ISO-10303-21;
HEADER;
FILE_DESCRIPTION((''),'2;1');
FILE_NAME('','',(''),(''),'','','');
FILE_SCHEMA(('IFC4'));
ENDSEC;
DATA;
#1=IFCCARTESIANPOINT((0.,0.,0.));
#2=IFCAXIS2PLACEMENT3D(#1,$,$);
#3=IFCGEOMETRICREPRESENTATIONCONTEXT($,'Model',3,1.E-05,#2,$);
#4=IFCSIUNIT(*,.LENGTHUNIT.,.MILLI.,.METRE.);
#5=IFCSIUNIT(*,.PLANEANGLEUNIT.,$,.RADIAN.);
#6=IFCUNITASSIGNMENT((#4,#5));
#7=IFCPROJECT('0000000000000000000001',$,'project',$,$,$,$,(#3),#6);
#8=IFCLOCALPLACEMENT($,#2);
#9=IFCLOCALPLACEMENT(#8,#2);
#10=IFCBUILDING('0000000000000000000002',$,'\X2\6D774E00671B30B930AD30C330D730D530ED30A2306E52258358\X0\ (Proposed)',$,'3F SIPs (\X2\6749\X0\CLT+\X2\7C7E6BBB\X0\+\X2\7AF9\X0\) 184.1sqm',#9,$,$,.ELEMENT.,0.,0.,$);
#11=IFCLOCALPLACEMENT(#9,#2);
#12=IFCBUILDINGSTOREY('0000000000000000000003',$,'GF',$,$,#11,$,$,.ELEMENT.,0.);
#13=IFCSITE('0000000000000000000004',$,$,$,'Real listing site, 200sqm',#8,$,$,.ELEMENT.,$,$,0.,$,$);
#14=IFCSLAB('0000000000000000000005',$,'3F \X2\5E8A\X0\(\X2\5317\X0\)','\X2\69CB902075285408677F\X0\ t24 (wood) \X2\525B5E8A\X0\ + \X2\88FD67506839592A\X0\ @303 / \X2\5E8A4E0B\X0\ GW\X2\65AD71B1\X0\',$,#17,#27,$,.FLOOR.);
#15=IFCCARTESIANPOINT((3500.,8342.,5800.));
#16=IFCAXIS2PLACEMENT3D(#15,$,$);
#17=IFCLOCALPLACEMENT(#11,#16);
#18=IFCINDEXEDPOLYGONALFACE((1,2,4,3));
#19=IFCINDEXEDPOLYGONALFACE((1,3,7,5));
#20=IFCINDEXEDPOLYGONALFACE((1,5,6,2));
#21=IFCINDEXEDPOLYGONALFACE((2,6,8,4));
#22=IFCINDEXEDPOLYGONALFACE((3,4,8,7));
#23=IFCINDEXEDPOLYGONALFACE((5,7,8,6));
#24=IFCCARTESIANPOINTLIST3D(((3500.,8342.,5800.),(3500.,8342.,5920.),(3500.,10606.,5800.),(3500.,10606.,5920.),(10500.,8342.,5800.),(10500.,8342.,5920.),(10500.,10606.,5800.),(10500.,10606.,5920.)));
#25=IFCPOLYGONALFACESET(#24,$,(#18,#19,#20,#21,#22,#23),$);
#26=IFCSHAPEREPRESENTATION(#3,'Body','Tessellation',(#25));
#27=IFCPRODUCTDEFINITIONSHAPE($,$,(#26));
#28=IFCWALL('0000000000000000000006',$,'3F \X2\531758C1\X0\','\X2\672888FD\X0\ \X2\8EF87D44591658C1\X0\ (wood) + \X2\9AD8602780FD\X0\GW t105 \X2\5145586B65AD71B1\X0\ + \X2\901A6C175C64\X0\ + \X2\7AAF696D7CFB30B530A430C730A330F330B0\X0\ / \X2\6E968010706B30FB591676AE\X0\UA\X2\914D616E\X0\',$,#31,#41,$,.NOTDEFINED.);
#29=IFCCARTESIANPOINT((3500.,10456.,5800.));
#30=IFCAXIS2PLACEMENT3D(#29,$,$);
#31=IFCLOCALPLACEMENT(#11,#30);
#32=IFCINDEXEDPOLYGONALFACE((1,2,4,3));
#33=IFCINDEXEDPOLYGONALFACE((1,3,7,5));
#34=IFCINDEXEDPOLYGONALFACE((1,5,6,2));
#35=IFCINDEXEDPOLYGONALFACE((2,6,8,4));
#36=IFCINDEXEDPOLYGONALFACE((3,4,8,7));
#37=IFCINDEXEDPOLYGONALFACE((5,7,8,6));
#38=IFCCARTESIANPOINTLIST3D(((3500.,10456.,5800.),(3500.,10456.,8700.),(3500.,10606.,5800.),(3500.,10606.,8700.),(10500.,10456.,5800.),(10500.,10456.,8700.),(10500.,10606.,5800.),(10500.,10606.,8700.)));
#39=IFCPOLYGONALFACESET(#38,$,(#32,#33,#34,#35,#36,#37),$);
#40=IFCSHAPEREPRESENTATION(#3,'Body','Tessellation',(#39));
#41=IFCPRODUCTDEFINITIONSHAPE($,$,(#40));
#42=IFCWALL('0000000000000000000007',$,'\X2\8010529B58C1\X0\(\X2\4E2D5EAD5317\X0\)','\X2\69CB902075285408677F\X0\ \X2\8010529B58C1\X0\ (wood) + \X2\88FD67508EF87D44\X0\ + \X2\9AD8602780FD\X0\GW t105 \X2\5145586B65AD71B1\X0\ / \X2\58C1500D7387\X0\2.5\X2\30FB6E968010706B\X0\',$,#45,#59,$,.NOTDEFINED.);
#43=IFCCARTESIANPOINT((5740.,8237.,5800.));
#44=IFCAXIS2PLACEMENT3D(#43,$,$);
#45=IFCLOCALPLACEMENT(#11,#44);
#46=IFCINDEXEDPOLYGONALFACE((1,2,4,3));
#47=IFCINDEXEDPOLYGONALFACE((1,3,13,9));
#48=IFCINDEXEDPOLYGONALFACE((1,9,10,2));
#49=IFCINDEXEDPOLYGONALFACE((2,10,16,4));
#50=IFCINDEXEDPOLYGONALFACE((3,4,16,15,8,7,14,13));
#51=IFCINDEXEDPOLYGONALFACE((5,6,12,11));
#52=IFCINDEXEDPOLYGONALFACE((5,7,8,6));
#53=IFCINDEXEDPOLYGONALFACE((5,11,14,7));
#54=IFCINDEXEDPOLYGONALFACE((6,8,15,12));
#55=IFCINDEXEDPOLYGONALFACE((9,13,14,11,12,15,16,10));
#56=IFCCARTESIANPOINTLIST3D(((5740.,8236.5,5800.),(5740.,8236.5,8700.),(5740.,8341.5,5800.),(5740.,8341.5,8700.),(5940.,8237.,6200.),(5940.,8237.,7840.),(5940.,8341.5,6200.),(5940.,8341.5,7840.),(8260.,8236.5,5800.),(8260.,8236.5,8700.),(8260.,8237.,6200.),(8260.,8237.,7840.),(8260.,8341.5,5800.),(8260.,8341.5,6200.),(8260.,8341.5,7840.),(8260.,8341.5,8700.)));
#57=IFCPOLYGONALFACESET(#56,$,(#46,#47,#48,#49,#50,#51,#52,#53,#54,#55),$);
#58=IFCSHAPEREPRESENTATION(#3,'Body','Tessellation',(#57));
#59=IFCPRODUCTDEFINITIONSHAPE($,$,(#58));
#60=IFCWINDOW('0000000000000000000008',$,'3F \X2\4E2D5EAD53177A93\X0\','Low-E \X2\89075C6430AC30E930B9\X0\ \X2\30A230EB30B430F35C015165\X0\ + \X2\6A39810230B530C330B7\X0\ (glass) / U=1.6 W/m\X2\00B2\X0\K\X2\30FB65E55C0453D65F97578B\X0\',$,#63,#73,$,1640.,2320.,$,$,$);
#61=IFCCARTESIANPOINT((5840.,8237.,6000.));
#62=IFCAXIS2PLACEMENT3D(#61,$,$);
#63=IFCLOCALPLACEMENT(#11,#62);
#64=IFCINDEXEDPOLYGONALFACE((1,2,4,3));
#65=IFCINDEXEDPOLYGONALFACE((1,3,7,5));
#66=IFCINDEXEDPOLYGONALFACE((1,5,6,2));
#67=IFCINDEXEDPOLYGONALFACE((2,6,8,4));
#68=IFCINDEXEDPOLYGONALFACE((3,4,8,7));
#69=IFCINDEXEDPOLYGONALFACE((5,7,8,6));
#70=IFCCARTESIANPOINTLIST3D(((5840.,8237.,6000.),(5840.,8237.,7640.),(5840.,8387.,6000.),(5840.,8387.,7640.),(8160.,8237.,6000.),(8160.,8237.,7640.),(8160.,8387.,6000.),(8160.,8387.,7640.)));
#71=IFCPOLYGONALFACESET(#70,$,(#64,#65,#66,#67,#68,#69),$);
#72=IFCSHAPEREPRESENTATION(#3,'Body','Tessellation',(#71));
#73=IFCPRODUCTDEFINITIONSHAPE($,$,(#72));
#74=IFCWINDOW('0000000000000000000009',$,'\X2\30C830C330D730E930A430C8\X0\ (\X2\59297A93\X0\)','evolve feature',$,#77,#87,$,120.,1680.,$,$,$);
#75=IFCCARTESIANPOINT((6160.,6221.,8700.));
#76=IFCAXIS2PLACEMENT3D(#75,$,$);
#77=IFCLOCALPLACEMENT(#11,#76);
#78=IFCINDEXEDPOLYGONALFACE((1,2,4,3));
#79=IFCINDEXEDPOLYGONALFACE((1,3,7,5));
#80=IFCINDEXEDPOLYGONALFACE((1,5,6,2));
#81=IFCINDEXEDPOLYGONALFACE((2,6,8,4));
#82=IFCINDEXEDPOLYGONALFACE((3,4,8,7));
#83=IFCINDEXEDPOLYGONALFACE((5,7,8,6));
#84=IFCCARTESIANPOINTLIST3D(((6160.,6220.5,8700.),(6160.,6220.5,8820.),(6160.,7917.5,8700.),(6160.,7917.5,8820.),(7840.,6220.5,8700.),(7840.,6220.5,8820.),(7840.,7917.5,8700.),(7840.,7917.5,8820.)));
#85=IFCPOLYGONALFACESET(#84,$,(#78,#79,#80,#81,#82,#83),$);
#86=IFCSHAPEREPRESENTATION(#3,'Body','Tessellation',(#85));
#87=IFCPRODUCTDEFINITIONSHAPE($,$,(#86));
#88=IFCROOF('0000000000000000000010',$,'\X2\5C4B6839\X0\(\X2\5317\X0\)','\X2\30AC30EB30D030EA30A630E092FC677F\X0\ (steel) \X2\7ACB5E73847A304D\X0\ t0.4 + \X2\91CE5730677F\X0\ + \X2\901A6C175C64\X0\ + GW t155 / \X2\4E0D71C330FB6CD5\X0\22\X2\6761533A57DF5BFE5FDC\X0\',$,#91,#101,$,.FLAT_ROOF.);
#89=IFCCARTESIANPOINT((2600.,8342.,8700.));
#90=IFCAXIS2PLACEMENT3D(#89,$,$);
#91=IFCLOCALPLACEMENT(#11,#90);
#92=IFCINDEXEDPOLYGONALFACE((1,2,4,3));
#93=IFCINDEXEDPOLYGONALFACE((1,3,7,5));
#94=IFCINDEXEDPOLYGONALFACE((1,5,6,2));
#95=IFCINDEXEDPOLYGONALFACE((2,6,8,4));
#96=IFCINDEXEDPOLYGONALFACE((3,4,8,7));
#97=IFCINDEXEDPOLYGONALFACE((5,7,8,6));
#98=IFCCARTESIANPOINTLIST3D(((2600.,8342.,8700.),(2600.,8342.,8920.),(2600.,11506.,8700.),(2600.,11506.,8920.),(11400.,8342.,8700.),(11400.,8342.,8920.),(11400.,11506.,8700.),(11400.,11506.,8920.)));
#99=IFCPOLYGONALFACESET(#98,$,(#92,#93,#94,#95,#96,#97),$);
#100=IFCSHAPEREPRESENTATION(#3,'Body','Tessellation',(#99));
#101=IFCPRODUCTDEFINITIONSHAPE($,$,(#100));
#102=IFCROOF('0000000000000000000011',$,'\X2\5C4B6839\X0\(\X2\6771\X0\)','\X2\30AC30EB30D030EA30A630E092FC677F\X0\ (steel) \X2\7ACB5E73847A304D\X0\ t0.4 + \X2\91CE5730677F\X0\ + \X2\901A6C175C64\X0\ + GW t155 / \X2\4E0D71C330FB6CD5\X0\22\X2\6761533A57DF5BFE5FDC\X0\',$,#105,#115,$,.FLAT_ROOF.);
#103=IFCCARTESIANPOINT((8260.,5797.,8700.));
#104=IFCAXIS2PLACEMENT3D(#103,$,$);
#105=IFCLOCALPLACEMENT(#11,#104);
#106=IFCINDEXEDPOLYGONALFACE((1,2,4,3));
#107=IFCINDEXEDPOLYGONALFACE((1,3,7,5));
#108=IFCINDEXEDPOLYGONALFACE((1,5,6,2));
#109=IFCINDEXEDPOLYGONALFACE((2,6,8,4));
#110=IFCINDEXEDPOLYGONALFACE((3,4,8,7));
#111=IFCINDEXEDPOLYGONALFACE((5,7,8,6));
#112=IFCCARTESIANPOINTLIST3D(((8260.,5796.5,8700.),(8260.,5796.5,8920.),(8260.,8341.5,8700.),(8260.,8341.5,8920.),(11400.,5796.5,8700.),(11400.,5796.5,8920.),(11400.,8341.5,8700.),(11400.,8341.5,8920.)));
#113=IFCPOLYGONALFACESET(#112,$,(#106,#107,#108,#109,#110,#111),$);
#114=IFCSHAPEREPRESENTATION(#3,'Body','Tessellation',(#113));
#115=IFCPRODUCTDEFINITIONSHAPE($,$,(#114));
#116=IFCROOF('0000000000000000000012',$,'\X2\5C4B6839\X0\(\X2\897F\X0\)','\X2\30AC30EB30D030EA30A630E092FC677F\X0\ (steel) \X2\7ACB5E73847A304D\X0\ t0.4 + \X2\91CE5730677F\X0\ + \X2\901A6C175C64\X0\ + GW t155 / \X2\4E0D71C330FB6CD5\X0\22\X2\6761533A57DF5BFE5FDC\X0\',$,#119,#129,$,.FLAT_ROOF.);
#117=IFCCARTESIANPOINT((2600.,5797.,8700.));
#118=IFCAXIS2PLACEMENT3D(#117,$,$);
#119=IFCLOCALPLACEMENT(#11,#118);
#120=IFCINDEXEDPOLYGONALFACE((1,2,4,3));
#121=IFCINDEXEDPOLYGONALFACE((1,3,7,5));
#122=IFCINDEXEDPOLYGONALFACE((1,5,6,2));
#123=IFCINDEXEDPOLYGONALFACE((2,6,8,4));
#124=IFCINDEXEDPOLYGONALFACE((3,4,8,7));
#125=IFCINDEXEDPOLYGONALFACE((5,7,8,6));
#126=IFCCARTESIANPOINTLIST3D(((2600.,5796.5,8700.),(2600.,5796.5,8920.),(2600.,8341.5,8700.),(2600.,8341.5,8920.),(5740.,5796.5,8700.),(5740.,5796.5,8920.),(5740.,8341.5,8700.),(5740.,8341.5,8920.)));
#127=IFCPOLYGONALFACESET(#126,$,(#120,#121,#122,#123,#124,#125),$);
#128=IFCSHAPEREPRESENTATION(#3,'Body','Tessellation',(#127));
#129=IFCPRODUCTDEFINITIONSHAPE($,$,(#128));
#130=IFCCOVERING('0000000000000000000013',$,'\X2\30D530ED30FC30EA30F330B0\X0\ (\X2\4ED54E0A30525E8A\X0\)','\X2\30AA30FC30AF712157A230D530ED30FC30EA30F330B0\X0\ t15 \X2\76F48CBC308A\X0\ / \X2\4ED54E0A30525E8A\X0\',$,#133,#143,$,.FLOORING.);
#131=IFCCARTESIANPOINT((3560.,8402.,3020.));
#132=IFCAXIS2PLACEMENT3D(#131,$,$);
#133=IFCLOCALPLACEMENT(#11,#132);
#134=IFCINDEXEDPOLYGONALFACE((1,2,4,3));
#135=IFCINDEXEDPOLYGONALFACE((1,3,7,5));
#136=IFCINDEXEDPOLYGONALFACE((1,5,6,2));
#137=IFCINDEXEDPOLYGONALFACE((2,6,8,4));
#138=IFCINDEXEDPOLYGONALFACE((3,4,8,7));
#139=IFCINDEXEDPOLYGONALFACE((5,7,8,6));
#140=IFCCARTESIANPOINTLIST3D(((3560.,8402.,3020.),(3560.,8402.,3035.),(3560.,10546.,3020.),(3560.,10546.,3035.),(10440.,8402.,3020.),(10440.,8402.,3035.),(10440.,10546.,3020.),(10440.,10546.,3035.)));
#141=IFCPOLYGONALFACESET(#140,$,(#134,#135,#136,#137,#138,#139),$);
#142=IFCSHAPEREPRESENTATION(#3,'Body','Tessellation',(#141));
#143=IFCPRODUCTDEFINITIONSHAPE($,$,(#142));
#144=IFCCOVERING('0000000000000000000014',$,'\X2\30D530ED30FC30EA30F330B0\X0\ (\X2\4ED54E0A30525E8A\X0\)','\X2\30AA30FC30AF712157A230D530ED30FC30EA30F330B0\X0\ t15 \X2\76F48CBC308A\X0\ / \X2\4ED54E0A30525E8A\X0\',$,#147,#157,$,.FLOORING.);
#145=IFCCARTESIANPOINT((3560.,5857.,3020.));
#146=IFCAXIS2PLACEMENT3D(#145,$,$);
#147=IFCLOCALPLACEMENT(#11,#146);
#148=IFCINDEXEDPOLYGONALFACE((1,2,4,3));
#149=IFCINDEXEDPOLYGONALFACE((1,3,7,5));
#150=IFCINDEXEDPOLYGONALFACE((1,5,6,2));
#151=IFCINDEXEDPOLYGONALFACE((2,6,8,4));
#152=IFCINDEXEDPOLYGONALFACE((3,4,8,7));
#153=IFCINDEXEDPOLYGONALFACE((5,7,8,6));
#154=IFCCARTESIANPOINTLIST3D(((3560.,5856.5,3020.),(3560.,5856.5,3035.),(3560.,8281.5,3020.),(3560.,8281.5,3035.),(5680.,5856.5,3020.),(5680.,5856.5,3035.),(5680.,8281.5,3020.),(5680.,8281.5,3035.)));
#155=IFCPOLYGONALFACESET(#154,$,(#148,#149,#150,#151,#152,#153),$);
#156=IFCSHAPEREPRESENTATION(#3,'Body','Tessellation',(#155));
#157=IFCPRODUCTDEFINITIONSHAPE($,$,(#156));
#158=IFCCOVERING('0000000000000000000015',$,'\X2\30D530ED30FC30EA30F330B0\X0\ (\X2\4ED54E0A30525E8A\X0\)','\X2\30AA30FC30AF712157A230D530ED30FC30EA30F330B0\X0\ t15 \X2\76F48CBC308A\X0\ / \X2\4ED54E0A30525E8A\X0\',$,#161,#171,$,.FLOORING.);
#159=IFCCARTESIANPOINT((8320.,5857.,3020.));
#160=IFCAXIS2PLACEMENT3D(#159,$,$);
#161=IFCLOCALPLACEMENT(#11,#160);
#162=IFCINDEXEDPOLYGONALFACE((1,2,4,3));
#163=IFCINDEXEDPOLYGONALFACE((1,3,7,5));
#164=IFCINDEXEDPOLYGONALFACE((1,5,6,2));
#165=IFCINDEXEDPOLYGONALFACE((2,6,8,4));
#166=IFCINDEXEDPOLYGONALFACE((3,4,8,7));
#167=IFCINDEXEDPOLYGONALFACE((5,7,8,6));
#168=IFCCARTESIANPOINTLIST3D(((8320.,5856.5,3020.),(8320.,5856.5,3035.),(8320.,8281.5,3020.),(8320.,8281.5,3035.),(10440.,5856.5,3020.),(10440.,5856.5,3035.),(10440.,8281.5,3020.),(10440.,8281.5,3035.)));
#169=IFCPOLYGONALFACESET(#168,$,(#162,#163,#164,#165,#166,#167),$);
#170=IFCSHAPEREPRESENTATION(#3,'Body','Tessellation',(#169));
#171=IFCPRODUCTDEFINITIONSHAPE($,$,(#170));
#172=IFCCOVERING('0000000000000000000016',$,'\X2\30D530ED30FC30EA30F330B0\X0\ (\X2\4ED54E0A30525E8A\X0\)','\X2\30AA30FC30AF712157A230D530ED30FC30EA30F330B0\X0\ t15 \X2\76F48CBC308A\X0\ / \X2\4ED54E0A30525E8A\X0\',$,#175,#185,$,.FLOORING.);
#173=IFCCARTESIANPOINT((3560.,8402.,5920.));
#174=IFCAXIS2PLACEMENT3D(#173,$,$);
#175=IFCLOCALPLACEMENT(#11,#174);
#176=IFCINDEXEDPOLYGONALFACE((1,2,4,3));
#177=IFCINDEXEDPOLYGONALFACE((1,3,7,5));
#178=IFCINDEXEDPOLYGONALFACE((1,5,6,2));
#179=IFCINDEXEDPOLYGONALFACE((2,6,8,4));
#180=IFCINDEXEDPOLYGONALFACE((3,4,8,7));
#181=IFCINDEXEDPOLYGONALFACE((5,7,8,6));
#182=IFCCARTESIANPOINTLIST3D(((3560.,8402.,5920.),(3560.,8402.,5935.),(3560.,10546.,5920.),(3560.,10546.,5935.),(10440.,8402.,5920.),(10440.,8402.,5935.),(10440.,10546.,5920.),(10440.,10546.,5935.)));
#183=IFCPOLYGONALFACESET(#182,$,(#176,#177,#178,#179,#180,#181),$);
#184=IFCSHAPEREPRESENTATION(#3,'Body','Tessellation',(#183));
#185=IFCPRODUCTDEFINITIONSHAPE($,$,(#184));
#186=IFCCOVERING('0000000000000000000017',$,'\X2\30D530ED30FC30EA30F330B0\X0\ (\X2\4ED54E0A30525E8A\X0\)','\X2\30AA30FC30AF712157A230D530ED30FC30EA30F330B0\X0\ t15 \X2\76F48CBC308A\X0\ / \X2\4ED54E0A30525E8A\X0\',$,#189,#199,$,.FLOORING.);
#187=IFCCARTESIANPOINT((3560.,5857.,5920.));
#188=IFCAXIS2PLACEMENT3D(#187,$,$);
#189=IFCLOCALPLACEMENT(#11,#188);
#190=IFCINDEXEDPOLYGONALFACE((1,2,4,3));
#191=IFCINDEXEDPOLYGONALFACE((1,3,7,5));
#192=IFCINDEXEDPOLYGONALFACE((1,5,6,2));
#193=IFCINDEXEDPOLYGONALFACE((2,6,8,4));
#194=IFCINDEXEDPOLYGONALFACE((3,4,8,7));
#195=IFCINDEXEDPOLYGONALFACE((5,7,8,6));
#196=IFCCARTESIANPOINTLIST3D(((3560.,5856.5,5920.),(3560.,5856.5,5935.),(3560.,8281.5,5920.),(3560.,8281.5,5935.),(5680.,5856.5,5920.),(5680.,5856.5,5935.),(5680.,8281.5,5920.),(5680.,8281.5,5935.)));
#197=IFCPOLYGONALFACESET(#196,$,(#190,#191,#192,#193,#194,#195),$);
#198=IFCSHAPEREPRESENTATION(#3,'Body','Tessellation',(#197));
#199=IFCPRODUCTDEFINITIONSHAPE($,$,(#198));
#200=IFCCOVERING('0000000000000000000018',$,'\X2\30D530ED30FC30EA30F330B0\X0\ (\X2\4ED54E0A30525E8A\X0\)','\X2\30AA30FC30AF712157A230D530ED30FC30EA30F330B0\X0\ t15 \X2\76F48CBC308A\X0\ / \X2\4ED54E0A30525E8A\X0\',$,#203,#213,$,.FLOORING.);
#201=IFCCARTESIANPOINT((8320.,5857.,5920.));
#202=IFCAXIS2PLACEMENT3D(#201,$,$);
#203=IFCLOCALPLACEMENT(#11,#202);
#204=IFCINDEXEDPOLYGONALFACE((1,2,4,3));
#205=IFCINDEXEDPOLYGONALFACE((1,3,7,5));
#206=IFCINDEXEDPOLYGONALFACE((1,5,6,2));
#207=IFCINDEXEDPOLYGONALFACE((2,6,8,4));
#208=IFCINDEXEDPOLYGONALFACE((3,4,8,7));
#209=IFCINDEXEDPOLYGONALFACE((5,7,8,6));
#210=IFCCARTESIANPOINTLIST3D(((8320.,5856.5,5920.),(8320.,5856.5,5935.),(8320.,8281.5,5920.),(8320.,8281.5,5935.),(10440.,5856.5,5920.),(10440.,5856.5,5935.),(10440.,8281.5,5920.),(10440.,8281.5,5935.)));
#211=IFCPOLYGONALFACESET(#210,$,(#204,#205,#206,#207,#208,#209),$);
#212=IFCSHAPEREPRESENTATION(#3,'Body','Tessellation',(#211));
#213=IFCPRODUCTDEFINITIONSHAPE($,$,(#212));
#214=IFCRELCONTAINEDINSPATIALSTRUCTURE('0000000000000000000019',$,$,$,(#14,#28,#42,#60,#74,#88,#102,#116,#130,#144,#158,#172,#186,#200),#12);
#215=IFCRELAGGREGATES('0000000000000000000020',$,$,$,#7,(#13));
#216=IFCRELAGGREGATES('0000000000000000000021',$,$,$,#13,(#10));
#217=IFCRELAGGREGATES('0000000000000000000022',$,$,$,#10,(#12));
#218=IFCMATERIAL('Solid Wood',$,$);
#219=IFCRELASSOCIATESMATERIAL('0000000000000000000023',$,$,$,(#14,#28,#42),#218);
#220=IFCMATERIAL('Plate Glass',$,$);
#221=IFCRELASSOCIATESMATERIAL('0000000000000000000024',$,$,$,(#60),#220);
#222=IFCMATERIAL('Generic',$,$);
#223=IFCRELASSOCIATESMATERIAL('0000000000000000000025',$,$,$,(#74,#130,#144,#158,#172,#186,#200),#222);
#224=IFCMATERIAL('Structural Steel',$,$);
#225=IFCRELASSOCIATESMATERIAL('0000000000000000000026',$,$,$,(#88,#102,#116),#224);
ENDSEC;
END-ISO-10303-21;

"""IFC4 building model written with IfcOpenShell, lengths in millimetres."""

from ifc_helpers import new_model, si_unit, frame, frame_2d, origin, place, context, project, spatial, rectangle, extrude, material, element, fill, save


model = new_model("IFC4")

# Units and contexts
model_context = context("Model", 3, precision=1e-05, world=origin())
ifc_project = project(units=[si_unit("LENGTHUNIT", "METRE", prefix="MILLI"), si_unit("PLANEANGLEUNIT", "RADIAN")], contexts=[model_context])

# Site, building, storey
site_placement = place(None, origin())
site = spatial("IfcSite", under=ifc_project, at=site_placement, ObjectType="Real listing site, 200sqm", CompositionType="ELEMENT", RefElevation=0.0)
building_placement = place(site_placement, origin())
building = spatial("IfcBuilding", under=site, at=building_placement, Name="海一望スキップフロアの別荘 (Proposed)", ObjectType="3F SIPs (杉CLT+籾殻+竹) 184.1sqm", CompositionType="ELEMENT", ElevationOfRefHeight=0.0, ElevationOfTerrain=0.0)
storey_placement = place(building_placement, origin())
storey = spatial("IfcBuildingStorey", under=building, at=storey_placement, Name="GF", CompositionType="ELEMENT", Elevation=0.0)

# Slab
ifc_material_1 = material(Name="Solid Wood")
slab_placement = place(storey_placement, frame((3500.0, 8342.0, 5800.0)))
element("IfcSlab", 1, at=slab_placement, inside=storey, material=ifc_material_1, Name="3F 床(北)", Description="構造用合板 t24 (wood) 剛床 + 製材根太 @303 / 床下 GW断熱", PredefinedType="FLOOR", context=model_context, shape_type="SweptSolid", body=[
    extrude(rectangle(XDim=7000.0, YDim=2264.0, at=frame_2d((3500.0, 1132.0))), frame((3500.0, 8342.0, 5800.0)), (0.0, 0.0, 1.0), 120.0),
])

# Wall
wall_1_placement = place(storey_placement, frame((3500.0, 10456.0, 5800.0)))
element("IfcWall", 2, at=wall_1_placement, inside=storey, material=ifc_material_1, Name="3F 北壁", Description="木製 軸組外壁 (wood) + 高性能GW t105 充填断熱 + 通気層 + 窯業系サイディング / 準耐火・外皮UA配慮", PredefinedType="NOTDEFINED", context=model_context, shape_type="SweptSolid", body=[
    extrude(rectangle(XDim=7000.0, YDim=150.0, at=frame_2d((3500.0, 75.0))), frame((3500.0, 10456.0, 5800.0)), (0.0, 0.0, 1.0), 2900.0),
])

# Wall, opening, window
wall_2_placement = place(storey_placement, frame((5740.0, 8237.0, 5800.0)))
wall_2 = element("IfcWall", 3, at=wall_2_placement, inside=storey, material=ifc_material_1, Name="耐力壁(中庭北)", Description="構造用合板 耐力壁 (wood) + 製材軸組 + 高性能GW t105 充填断熱 / 壁倍率2.5・準耐火", PredefinedType="NOTDEFINED", context=model_context, shape_type="SweptSolid", body=[
    extrude(rectangle(XDim=2520.0, YDim=105.0, at=frame_2d((1260.0, 52.0))), frame((5740.0, 8237.0, 5800.0)), (0.0, 0.0, 1.0), 2900.0),
])
opening_placement = place(storey_placement, frame((5840.0, 8237.0, 6000.0)))
opening = element("IfcOpeningElement", 4, at=opening_placement, cuts=wall_2, PredefinedType="NOTDEFINED", context=model_context, shape_type="SweptSolid", body=[
    extrude(rectangle(XDim=2320.0, YDim=150.0, at=frame_2d((1160.0, 75.0))), frame((5840.0, 8237.0, 6000.0)), (0.0, 0.0, 1.0), 1640.0),
])
ifc_material_2 = material(Name="Plate Glass")
window_1_placement = place(storey_placement, frame((5840.0, 8237.0, 6000.0)))
window_1 = element("IfcWindow", 5, at=window_1_placement, inside=storey, material=ifc_material_2, Name="3F 中庭北窓", Description="Low-E 複層ガラス アルゴン封入 + 樹脂サッシ (glass) / U=1.6 W/m²K・日射取得型", OverallHeight=1640.0, OverallWidth=2320.0, context=model_context, shape_type="SweptSolid", body=[
    extrude(rectangle(XDim=2320.0, YDim=150.0, at=frame_2d((1160.0, 75.0))), frame((5840.0, 8237.0, 6000.0)), (0.0, 0.0, 1.0), 1640.0),
])
fill(opening, window_1)

# Window
ifc_material_3 = material(Name="Generic")
window_2_placement = place(storey_placement, frame((6160.0, 6221.0, 8700.0)))
element("IfcWindow", 6, at=window_2_placement, inside=storey, material=ifc_material_3, Name="トップライト (天窓)", Description="evolve feature", OverallHeight=120.0, OverallWidth=1680.0, context=model_context, shape_type="SweptSolid", body=[
    extrude(rectangle(XDim=1680.0, YDim=1697.0, at=frame_2d((840.0, 848.0))), frame((6160.0, 6221.0, 8700.0)), (0.0, 0.0, 1.0), 120.0),
])

# Roofs
ifc_material_4 = material(Name="Structural Steel")
roof_1_placement = place(storey_placement, frame((2600.0, 8342.0, 8700.0)))
element("IfcRoof", 7, at=roof_1_placement, inside=storey, material=ifc_material_4, Name="屋根(北)", Description="ガルバリウム鋼板 (steel) 立平葺き t0.4 + 野地板 + 通気層 + GW t155 / 不燃・法22条区域対応", PredefinedType="FLAT_ROOF", context=model_context, shape_type="SweptSolid", body=[
    extrude(rectangle(XDim=8800.0, YDim=3164.0, at=frame_2d((4400.0, 1582.0))), frame((2600.0, 8342.0, 8700.0)), (0.0, 0.0, 1.0), 220.0),
])
roof_2_placement = place(storey_placement, frame((8260.0, 5797.0, 8700.0)))
element("IfcRoof", 8, at=roof_2_placement, inside=storey, material=ifc_material_4, Name="屋根(東)", Description="ガルバリウム鋼板 (steel) 立平葺き t0.4 + 野地板 + 通気層 + GW t155 / 不燃・法22条区域対応", PredefinedType="FLAT_ROOF", context=model_context, shape_type="SweptSolid", body=[
    extrude(rectangle(XDim=3140.0, YDim=2545.0, at=frame_2d((1570.0, 1272.0))), frame((8260.0, 5797.0, 8700.0)), (0.0, 0.0, 1.0), 220.0),
])
roof_3_placement = place(storey_placement, frame((2600.0, 5797.0, 8700.0)))
element("IfcRoof", 9, at=roof_3_placement, inside=storey, material=ifc_material_4, Name="屋根(西)", Description="ガルバリウム鋼板 (steel) 立平葺き t0.4 + 野地板 + 通気層 + GW t155 / 不燃・法22条区域対応", PredefinedType="FLAT_ROOF", context=model_context, shape_type="SweptSolid", body=[
    extrude(rectangle(XDim=3140.0, YDim=2545.0, at=frame_2d((1570.0, 1272.0))), frame((2600.0, 5797.0, 8700.0)), (0.0, 0.0, 1.0), 220.0),
])

# Coverings
covering_1_placement = place(storey_placement, frame((3560.0, 8402.0, 3020.0)))
element("IfcCovering", 10, at=covering_1_placement, inside=storey, material=ifc_material_3, Name="フローリング (仕上げ床)", Description="オーク無垢フローリング t15 直貼り / 仕上げ床", PredefinedType="FLOORING", context=model_context, shape_type="SweptSolid", body=[
    extrude(rectangle(XDim=6880.0, YDim=2144.0, at=frame_2d((3440.0, 1072.0))), frame((3560.0, 8402.0, 3020.0)), (0.0, 0.0, 1.0), 15.0),
])
covering_2_placement = place(storey_placement, frame((3560.0, 5857.0, 3020.0)))
element("IfcCovering", 11, at=covering_2_placement, inside=storey, material=ifc_material_3, Name="フローリング (仕上げ床)", Description="オーク無垢フローリング t15 直貼り / 仕上げ床", PredefinedType="FLOORING", context=model_context, shape_type="SweptSolid", body=[
    extrude(rectangle(XDim=2120.0, YDim=2425.0, at=frame_2d((1060.0, 1212.0))), frame((3560.0, 5857.0, 3020.0)), (0.0, 0.0, 1.0), 15.0),
])
covering_3_placement = place(storey_placement, frame((8320.0, 5857.0, 3020.0)))
element("IfcCovering", 12, at=covering_3_placement, inside=storey, material=ifc_material_3, Name="フローリング (仕上げ床)", Description="オーク無垢フローリング t15 直貼り / 仕上げ床", PredefinedType="FLOORING", context=model_context, shape_type="SweptSolid", body=[
    extrude(rectangle(XDim=2120.0, YDim=2425.0, at=frame_2d((1060.0, 1212.0))), frame((8320.0, 5857.0, 3020.0)), (0.0, 0.0, 1.0), 15.0),
])
covering_4_placement = place(storey_placement, frame((3560.0, 8402.0, 5920.0)))
element("IfcCovering", 13, at=covering_4_placement, inside=storey, material=ifc_material_3, Name="フローリング (仕上げ床)", Description="オーク無垢フローリング t15 直貼り / 仕上げ床", PredefinedType="FLOORING", context=model_context, shape_type="SweptSolid", body=[
    extrude(rectangle(XDim=6880.0, YDim=2144.0, at=frame_2d((3440.0, 1072.0))), frame((3560.0, 8402.0, 5920.0)), (0.0, 0.0, 1.0), 15.0),
])
covering_5_placement = place(storey_placement, frame((3560.0, 5857.0, 5920.0)))
element("IfcCovering", 14, at=covering_5_placement, inside=storey, material=ifc_material_3, Name="フローリング (仕上げ床)", Description="オーク無垢フローリング t15 直貼り / 仕上げ床", PredefinedType="FLOORING", context=model_context, shape_type="SweptSolid", body=[
    extrude(rectangle(XDim=2120.0, YDim=2425.0, at=frame_2d((1060.0, 1212.0))), frame((3560.0, 5857.0, 5920.0)), (0.0, 0.0, 1.0), 15.0),
])
covering_6_placement = place(storey_placement, frame((8320.0, 5857.0, 5920.0)))
element("IfcCovering", 15, at=covering_6_placement, inside=storey, material=ifc_material_3, Name="フローリング (仕上げ床)", Description="オーク無垢フローリング t15 直貼り / 仕上げ床", PredefinedType="FLOORING", context=model_context, shape_type="SweptSolid", body=[
    extrude(rectangle(XDim=2120.0, YDim=2425.0, at=frame_2d((1060.0, 1212.0))), frame((8320.0, 5857.0, 5920.0)), (0.0, 0.0, 1.0), 15.0),
])

save(model, "model.ifc")
